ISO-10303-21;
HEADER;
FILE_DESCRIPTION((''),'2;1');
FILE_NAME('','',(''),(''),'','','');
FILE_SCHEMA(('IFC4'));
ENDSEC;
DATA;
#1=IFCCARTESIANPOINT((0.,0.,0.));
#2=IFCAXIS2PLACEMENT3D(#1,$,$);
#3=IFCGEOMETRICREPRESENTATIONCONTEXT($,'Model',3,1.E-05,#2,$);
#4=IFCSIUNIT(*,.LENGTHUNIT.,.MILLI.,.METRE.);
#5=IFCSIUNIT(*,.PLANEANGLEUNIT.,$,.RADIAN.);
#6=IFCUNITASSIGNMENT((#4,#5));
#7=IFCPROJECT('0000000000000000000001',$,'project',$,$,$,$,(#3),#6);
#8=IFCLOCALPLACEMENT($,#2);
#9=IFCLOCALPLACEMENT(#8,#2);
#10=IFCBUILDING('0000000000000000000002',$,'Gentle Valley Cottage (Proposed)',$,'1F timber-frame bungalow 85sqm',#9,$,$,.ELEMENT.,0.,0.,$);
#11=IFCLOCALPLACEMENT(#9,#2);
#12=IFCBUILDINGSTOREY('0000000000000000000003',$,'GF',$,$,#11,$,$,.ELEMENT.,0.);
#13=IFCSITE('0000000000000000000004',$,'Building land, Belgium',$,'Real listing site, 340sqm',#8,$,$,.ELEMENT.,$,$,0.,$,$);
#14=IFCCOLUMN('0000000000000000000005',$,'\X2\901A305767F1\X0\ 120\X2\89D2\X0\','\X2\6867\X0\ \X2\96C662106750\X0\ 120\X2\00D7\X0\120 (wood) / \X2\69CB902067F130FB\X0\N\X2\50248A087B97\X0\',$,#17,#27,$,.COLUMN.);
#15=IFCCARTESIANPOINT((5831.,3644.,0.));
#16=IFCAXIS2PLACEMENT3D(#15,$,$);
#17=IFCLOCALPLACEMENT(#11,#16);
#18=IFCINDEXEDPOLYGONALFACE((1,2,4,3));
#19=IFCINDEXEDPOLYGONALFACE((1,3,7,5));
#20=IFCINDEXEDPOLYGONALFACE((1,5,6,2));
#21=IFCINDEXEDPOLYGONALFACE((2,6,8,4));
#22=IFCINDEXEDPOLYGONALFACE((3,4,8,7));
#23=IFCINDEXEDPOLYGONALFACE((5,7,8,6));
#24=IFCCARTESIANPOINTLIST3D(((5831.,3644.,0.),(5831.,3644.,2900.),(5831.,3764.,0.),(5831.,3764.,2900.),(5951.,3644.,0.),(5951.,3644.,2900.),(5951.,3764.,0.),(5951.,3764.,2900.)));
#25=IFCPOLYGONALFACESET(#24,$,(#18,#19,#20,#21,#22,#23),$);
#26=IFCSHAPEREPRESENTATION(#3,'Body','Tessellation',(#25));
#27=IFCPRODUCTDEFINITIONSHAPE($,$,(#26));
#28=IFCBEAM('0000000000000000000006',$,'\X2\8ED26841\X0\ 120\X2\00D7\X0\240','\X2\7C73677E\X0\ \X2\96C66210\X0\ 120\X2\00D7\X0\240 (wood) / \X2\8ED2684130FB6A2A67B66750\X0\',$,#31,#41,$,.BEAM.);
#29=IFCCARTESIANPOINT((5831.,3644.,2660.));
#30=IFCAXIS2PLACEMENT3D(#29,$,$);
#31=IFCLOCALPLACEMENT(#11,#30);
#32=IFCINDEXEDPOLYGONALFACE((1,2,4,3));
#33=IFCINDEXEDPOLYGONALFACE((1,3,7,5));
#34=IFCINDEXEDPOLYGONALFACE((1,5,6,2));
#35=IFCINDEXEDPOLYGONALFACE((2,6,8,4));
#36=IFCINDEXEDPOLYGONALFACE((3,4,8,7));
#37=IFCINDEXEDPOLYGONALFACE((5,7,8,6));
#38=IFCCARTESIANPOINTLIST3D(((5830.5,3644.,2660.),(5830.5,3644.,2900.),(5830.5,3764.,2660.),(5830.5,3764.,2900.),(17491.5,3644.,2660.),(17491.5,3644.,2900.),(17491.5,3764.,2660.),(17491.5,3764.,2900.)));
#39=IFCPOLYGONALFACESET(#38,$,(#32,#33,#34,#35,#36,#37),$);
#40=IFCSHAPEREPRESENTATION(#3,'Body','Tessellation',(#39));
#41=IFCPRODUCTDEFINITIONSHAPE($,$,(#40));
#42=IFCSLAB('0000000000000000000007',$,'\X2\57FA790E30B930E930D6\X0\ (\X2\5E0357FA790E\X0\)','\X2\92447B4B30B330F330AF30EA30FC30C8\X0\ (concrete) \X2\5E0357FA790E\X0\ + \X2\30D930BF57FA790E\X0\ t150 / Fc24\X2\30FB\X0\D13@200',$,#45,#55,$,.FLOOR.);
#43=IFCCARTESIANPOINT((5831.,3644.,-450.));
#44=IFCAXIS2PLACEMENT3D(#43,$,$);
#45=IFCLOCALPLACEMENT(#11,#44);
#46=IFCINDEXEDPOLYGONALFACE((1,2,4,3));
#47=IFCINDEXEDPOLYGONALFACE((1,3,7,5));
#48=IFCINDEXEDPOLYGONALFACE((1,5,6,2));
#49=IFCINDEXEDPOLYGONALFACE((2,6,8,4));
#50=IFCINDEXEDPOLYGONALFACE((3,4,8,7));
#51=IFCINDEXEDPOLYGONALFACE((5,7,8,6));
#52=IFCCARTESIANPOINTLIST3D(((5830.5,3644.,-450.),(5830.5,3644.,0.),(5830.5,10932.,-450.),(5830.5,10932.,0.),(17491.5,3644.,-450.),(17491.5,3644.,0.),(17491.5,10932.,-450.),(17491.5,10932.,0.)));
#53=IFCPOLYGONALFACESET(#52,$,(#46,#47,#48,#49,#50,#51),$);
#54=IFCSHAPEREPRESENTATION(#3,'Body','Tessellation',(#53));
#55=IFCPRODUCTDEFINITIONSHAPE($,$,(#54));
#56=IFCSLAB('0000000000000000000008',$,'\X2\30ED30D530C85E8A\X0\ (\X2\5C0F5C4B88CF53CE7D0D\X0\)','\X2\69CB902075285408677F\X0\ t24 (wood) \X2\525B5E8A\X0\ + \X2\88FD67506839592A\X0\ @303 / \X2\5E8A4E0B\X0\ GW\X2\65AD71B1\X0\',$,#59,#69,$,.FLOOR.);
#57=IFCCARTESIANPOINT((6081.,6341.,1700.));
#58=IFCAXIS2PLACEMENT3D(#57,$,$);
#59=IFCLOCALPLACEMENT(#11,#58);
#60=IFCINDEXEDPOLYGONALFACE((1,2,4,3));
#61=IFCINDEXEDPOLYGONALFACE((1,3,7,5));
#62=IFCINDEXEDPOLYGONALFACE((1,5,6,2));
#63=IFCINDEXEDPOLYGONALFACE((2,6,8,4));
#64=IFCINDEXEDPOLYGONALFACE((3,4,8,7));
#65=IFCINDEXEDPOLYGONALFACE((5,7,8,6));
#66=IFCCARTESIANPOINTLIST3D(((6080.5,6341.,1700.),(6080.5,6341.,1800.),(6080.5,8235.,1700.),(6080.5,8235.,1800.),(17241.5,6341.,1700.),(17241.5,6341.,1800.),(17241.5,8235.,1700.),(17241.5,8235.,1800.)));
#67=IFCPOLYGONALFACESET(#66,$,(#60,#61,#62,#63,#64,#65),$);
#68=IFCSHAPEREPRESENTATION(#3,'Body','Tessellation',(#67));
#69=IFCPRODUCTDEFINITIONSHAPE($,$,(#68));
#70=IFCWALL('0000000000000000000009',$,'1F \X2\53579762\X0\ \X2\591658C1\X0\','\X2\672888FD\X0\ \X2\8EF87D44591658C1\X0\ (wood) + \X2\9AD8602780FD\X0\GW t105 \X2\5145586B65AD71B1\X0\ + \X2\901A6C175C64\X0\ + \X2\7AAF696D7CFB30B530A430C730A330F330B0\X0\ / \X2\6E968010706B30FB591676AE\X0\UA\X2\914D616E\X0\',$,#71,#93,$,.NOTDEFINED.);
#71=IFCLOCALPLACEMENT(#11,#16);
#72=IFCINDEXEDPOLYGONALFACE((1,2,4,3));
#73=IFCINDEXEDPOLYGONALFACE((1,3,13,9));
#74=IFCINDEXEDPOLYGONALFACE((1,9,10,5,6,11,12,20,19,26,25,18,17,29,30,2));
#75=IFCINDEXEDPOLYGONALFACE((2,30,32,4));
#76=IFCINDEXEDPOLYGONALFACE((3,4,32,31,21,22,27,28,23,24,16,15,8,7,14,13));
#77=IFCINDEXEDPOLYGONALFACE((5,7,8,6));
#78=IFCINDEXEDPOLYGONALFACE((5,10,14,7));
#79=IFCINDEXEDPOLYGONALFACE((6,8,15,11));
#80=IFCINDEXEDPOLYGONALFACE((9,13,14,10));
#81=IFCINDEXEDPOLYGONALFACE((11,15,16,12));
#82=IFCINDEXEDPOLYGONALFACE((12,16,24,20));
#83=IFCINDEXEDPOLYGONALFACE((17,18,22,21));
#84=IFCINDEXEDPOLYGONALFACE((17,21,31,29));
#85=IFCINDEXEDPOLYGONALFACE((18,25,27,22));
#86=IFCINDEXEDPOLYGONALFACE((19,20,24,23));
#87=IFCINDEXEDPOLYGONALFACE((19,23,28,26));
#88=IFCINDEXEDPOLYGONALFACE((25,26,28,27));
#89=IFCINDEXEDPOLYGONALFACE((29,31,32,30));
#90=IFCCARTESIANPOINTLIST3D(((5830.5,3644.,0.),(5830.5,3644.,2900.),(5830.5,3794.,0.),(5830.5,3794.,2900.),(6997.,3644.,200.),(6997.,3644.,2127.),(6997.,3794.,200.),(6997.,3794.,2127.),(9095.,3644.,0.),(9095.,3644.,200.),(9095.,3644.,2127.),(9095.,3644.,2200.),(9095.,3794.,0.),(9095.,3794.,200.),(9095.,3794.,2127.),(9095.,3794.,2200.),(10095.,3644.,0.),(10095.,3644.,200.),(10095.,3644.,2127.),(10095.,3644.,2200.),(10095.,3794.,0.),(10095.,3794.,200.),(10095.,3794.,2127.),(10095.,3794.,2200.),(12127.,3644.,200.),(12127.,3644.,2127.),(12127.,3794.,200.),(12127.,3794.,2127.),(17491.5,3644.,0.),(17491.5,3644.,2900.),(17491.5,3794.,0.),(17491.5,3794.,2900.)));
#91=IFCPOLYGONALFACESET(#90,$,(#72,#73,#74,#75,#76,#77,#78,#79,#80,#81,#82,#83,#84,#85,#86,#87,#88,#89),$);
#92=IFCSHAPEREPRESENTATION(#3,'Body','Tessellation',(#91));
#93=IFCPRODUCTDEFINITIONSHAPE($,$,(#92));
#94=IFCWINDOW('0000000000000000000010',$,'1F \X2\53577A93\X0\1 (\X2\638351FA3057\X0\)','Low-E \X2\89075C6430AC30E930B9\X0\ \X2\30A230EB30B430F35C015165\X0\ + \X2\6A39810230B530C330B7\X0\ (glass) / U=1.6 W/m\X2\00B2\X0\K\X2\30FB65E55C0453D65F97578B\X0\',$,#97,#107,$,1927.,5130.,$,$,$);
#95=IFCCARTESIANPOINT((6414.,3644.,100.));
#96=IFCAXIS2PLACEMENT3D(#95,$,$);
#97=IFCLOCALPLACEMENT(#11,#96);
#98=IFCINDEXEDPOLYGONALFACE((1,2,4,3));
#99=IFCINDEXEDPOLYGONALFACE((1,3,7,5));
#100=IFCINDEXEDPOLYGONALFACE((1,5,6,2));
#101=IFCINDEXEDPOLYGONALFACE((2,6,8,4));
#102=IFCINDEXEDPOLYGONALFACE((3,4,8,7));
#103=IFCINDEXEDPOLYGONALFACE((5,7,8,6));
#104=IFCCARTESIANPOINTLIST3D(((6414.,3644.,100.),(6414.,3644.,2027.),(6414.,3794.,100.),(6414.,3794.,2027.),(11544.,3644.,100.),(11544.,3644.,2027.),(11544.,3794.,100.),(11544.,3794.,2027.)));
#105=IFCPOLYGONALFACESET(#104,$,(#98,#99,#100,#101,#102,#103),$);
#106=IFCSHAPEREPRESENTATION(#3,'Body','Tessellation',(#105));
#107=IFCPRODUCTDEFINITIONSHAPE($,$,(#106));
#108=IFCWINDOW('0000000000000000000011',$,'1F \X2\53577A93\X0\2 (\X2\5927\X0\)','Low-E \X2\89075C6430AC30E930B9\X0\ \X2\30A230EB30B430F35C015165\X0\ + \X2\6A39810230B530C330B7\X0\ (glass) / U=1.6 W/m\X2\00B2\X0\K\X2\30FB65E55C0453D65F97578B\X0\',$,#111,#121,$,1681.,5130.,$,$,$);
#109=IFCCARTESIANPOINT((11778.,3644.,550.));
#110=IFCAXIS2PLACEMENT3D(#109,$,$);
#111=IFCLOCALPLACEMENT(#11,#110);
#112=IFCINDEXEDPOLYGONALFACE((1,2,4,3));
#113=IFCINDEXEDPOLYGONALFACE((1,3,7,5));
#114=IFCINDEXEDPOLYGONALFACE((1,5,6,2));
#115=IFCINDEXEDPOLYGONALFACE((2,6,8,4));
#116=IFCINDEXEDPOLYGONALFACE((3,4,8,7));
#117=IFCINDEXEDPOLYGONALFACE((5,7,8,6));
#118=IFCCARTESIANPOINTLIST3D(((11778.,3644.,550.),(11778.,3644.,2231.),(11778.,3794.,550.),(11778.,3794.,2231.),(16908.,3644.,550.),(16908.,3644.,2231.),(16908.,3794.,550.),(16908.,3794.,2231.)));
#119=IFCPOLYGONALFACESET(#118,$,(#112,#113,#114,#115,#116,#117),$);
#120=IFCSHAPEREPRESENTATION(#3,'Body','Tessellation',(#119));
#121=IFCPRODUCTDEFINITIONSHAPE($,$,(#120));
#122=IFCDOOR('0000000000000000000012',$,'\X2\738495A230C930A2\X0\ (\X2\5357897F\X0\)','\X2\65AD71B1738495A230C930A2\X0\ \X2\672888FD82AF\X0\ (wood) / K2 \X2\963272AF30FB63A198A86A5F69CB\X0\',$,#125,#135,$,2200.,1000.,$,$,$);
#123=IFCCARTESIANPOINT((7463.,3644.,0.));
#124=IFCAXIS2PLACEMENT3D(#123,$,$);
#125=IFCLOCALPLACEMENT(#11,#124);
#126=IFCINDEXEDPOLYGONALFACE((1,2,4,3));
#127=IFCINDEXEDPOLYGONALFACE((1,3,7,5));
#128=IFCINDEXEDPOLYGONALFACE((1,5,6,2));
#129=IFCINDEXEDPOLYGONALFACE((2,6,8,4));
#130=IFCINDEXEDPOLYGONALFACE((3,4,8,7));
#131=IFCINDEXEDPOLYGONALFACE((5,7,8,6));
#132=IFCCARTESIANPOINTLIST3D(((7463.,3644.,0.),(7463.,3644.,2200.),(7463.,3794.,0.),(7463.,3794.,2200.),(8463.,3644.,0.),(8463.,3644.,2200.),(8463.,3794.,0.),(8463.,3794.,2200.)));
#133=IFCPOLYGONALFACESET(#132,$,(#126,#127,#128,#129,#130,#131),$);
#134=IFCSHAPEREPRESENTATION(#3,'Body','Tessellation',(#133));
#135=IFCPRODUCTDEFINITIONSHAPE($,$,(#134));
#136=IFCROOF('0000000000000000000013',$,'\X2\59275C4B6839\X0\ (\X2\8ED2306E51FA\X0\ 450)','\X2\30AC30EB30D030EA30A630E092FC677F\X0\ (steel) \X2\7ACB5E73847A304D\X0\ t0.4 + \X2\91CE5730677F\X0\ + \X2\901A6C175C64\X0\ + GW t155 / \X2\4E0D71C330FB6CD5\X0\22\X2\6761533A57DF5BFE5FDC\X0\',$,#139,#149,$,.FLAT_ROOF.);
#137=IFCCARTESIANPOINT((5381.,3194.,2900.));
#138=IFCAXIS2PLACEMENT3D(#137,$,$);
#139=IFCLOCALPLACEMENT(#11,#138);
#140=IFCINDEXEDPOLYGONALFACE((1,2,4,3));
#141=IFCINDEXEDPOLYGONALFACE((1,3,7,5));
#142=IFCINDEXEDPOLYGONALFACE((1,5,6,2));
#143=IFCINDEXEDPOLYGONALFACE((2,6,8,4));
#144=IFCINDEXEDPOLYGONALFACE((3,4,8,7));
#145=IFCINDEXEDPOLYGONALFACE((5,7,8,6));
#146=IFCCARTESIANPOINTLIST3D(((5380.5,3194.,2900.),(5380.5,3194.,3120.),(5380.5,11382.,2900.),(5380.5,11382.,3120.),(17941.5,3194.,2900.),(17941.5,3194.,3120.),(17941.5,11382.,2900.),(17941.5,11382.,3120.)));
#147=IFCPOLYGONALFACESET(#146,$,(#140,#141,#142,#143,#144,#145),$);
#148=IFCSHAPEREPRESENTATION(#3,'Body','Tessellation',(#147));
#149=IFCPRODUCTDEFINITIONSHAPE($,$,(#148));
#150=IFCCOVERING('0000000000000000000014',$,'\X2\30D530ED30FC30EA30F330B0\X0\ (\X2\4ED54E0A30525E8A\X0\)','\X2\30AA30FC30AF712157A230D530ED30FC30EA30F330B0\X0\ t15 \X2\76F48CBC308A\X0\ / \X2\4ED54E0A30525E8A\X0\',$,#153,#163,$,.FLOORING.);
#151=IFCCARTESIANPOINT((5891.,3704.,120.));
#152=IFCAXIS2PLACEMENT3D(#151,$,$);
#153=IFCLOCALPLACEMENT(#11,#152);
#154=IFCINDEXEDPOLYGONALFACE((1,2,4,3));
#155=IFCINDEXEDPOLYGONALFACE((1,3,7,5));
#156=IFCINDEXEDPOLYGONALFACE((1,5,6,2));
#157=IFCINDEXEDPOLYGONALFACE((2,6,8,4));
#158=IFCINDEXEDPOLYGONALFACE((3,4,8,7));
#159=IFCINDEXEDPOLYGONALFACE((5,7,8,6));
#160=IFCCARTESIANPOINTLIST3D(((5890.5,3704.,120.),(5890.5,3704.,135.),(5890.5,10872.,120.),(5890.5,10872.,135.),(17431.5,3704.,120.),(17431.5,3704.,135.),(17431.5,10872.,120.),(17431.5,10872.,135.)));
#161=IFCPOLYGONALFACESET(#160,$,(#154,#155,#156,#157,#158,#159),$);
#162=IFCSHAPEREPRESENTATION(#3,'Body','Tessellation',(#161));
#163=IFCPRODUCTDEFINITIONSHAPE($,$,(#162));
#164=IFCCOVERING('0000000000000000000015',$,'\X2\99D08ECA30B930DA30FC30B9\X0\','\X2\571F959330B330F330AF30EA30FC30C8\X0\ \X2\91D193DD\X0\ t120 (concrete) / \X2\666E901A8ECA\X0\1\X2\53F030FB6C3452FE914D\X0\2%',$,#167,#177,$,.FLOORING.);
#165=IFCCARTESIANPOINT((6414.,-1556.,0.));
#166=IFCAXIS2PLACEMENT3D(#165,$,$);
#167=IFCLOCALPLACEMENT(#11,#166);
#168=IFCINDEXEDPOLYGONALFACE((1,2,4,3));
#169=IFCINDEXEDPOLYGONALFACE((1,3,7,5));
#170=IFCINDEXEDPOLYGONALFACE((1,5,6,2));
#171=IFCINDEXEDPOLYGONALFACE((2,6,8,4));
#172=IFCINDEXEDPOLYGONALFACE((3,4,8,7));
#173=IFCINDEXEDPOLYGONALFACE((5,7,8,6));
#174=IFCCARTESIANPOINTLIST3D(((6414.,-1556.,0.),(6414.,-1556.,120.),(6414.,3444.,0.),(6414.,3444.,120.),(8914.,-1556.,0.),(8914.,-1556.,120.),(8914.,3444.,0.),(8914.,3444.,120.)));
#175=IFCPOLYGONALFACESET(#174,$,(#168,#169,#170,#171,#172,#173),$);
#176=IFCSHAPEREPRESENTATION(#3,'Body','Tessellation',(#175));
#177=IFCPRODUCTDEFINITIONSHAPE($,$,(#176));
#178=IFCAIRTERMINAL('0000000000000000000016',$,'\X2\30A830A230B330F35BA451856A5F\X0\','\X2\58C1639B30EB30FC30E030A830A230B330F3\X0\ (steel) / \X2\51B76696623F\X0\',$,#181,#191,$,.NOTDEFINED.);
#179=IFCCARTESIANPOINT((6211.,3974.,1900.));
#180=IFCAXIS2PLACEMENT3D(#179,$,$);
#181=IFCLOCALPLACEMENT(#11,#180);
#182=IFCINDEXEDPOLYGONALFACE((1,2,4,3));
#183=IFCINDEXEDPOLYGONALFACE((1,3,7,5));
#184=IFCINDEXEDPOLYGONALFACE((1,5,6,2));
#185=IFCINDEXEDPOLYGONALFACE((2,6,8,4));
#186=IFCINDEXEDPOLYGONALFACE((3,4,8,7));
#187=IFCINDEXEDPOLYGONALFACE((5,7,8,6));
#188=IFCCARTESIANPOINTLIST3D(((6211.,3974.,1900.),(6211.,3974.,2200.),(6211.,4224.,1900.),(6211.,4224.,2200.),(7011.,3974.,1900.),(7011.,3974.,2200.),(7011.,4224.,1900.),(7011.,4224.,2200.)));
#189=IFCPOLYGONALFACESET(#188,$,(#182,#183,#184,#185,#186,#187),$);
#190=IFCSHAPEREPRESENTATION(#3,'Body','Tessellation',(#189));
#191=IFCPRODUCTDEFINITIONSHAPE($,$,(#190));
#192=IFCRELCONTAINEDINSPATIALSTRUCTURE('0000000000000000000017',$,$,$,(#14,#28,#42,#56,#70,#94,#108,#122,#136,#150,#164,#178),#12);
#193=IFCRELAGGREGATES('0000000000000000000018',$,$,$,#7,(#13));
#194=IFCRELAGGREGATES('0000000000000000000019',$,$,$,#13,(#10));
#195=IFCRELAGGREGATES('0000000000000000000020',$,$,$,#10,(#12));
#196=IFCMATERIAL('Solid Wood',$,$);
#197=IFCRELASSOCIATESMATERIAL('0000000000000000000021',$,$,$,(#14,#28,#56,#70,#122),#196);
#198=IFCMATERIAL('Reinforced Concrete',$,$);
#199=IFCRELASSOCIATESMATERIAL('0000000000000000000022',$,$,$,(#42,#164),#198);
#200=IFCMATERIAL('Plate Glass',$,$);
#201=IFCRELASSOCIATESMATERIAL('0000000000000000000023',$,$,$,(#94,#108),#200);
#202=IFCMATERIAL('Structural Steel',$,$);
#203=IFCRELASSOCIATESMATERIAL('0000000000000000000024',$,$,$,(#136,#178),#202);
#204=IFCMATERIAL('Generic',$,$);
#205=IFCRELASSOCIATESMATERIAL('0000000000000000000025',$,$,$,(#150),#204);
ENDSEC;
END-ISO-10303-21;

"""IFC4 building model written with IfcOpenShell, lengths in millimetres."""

from ifc_helpers import new_model, si_unit, frame, frame_2d, origin, place, context, project, spatial, rectangle, extrude, material, element, fill, save


model = new_model("IFC4")

# Units and contexts
model_context = context("Model", 3, precision=1e-05, world=origin())
ifc_project = project(units=[si_unit("LENGTHUNIT", "METRE", prefix="MILLI"), si_unit("PLANEANGLEUNIT", "RADIAN")], contexts=[model_context])

# Site, building, storey
site_placement = place(None, origin())
site = spatial("IfcSite", under=ifc_project, at=site_placement, Name="Building land, Belgium", ObjectType="Real listing site, 340sqm", CompositionType="ELEMENT", RefElevation=0.0)
building_placement = place(site_placement, origin())
building = spatial("IfcBuilding", under=site, at=building_placement, Name="Gentle Valley Cottage (Proposed)", ObjectType="1F timber-frame bungalow 85sqm", CompositionType="ELEMENT", ElevationOfRefHeight=0.0, ElevationOfTerrain=0.0)
storey_placement = place(building_placement, origin())
storey = spatial("IfcBuildingStorey", under=building, at=storey_placement, Name="GF", CompositionType="ELEMENT", Elevation=0.0)

# Column
ifc_material_1 = material(Name="Solid Wood")
column_1_placement = place(storey_placement, frame((5831.0, 3644.0, 0.0)))
element("IfcColumn", 1, at=column_1_placement, inside=storey, material=ifc_material_1, Name="通し柱 120角", Description="桧 集成材 120×120 (wood) / 構造柱・N値計算", PredefinedType="COLUMN", context=model_context, shape_type="SweptSolid", body=[
    extrude(rectangle(XDim=120.0, YDim=120.0, at=frame_2d((60.0, 60.0))), frame((5831.0, 3644.0, 0.0)), (0.0, 0.0, 1.0), 2900.0),
])

# Beam
beam_1_placement = place(storey_placement, frame((5831.0, 3644.0, 2660.0)))
element("IfcBeam", 2, at=beam_1_placement, inside=storey, material=ifc_material_1, Name="軒桁 120×240", Description="米松 集成 120×240 (wood) / 軒桁・横架材", PredefinedType="BEAM", context=model_context, shape_type="SweptSolid", body=[
    extrude(rectangle(XDim=11661.0, YDim=120.0, at=frame_2d((5830.0, 60.0))), frame((5831.0, 3644.0, 2660.0)), (0.0, 0.0, 1.0), 240.0),
])

# Slabs
ifc_material_2 = material(Name="Reinforced Concrete")
slab_1_placement = place(storey_placement, frame((5831.0, 3644.0, -450.0)))
element("IfcSlab", 3, at=slab_1_placement, inside=storey, material=ifc_material_2, Name="基礎スラブ (布基礎)", Description="鉄筋コンクリート (concrete) 布基礎 + ベタ基礎 t150 / Fc24・D13@200", PredefinedType="FLOOR", context=model_context, shape_type="SweptSolid", body=[
    extrude(rectangle(XDim=11661.0, YDim=7288.0, at=frame_2d((5830.0, 3644.0))), frame((5831.0, 3644.0, -450.0)), (0.0, 0.0, 1.0), 450.0),
])
slab_2_placement = place(storey_placement, frame((6081.0, 6341.0, 1700.0)))
element("IfcSlab", 4, at=slab_2_placement, inside=storey, material=ifc_material_1, Name="ロフト床 (小屋裏収納)", Description="構造用合板 t24 (wood) 剛床 + 製材根太 @303 / 床下 GW断熱", PredefinedType="FLOOR", context=model_context, shape_type="SweptSolid", body=[
    extrude(rectangle(XDim=11161.0, YDim=1894.0, at=frame_2d((5580.0, 947.0))), frame((6081.0, 6341.0, 1700.0)), (0.0, 0.0, 1.0), 100.0),
])

# Wall, openings, windows, door
wall_1_placement = place(storey_placement, frame((5831.0, 3644.0, 0.0)))
wall_1 = element("IfcWall", 5, at=wall_1_placement, inside=storey, material=ifc_material_1, Name="1F 南面 外壁", Description="木製 軸組外壁 (wood) + 高性能GW t105 充填断熱 + 通気層 + 窯業系サイディング / 準耐火・外皮UA配慮", PredefinedType="NOTDEFINED", context=model_context, shape_type="SweptSolid", body=[
    extrude(rectangle(XDim=11661.0, YDim=150.0, at=frame_2d((5830.0, 75.0))), frame((5831.0, 3644.0, 0.0)), (0.0, 0.0, 1.0), 2900.0),
])
opening_1_placement = place(storey_placement, frame((6414.0, 3644.0, 100.0)))
opening_1 = element("IfcOpeningElement", 6, at=opening_1_placement, cuts=wall_1, PredefinedType="NOTDEFINED", context=model_context, shape_type="SweptSolid", body=[
    extrude(rectangle(XDim=5130.0, YDim=150.0, at=frame_2d((2565.0, 75.0))), frame((6414.0, 3644.0, 100.0)), (0.0, 0.0, 1.0), 1927.0),
])
opening_2_placement = place(storey_placement, frame((11778.0, 3644.0, 550.0)))
opening_2 = element("IfcOpeningElement", 7, at=opening_2_placement, cuts=wall_1, PredefinedType="NOTDEFINED", context=model_context, shape_type="SweptSolid", body=[
    extrude(rectangle(XDim=5130.0, YDim=150.0, at=frame_2d((2565.0, 75.0))), frame((11778.0, 3644.0, 550.0)), (0.0, 0.0, 1.0), 1681.0),
])
opening_3_placement = place(storey_placement, frame((7463.0, 3644.0, 0.0)))
opening_3 = element("IfcOpeningElement", 8, at=opening_3_placement, cuts=wall_1, PredefinedType="NOTDEFINED", context=model_context, shape_type="SweptSolid", body=[
    extrude(rectangle(XDim=1000.0, YDim=150.0, at=frame_2d((500.0, 75.0))), frame((7463.0, 3644.0, 0.0)), (0.0, 0.0, 1.0), 2200.0),
])
ifc_material_3 = material(Name="Plate Glass")
window_1_placement = place(storey_placement, frame((6414.0, 3644.0, 100.0)))
window_1 = element("IfcWindow", 9, at=window_1_placement, inside=storey, material=ifc_material_3, Name="1F 南窓1 (掃出し)", Description="Low-E 複層ガラス アルゴン封入 + 樹脂サッシ (glass) / U=1.6 W/m²K・日射取得型", OverallHeight=1927.0, OverallWidth=5130.0, context=model_context, shape_type="SweptSolid", body=[
    extrude(rectangle(XDim=5130.0, YDim=150.0, at=frame_2d((2565.0, 75.0))), frame((6414.0, 3644.0, 100.0)), (0.0, 0.0, 1.0), 1927.0),
])
fill(opening_1, window_1)
window_2_placement = place(storey_placement, frame((11778.0, 3644.0, 550.0)))
window_2 = element("IfcWindow", 10, at=window_2_placement, inside=storey, material=ifc_material_3, Name="1F 南窓2 (大)", Description="Low-E 複層ガラス アルゴン封入 + 樹脂サッシ (glass) / U=1.6 W/m²K・日射取得型", OverallHeight=1681.0, OverallWidth=5130.0, context=model_context, shape_type="SweptSolid", body=[
    extrude(rectangle(XDim=5130.0, YDim=150.0, at=frame_2d((2565.0, 75.0))), frame((11778.0, 3644.0, 550.0)), (0.0, 0.0, 1.0), 1681.0),
])
fill(opening_2, window_2)
door_placement = place(storey_placement, frame((7463.0, 3644.0, 0.0)))
door = element("IfcDoor", 11, at=door_placement, inside=storey, material=ifc_material_1, Name="玄関ドア (南西)", Description="断熱玄関ドア 木製芯 (wood) / K2 防犯・採風機構", OverallHeight=2200.0, OverallWidth=1000.0, context=model_context, shape_type="SweptSolid", body=[
    extrude(rectangle(XDim=1000.0, YDim=150.0, at=frame_2d((500.0, 75.0))), frame((7463.0, 3644.0, 0.0)), (0.0, 0.0, 1.0), 2200.0),
])
fill(opening_3, door)

# Roof
ifc_material_4 = material(Name="Structural Steel")
roof_placement = place(storey_placement, frame((5381.0, 3194.0, 2900.0)))
element("IfcRoof", 12, at=roof_placement, inside=storey, material=ifc_material_4, Name="大屋根 (軒の出 450)", Description="ガルバリウム鋼板 (steel) 立平葺き t0.4 + 野地板 + 通気層 + GW t155 / 不燃・法22条区域対応", PredefinedType="FLAT_ROOF", context=model_context, shape_type="SweptSolid", body=[
    extrude(rectangle(XDim=12561.0, YDim=8188.0, at=frame_2d((6280.0, 4094.0))), frame((5381.0, 3194.0, 2900.0)), (0.0, 0.0, 1.0), 220.0),
])

# Coverings
ifc_material_5 = material(Name="Generic")
covering_1_placement = place(storey_placement, frame((5891.0, 3704.0, 120.0)))
element("IfcCovering", 13, at=covering_1_placement, inside=storey, material=ifc_material_5, Name="フローリング (仕上げ床)", Description="オーク無垢フローリング t15 直貼り / 仕上げ床", PredefinedType="FLOORING", context=model_context, shape_type="SweptSolid", body=[
    extrude(rectangle(XDim=11541.0, YDim=7168.0, at=frame_2d((5770.0, 3584.0))), frame((5891.0, 3704.0, 120.0)), (0.0, 0.0, 1.0), 15.0),
])
covering_2_placement = place(storey_placement, frame((6414.0, -1556.0, 0.0)))
element("IfcCovering", 14, at=covering_2_placement, inside=storey, material=ifc_material_2, Name="駐車スペース", Description="土間コンクリート 金鏝 t120 (concrete) / 普通車1台・水勾配2%", PredefinedType="FLOORING", context=model_context, shape_type="SweptSolid", body=[
    extrude(rectangle(XDim=2500.0, YDim=5000.0, at=frame_2d((1250.0, 2500.0))), frame((6414.0, -1556.0, 0.0)), (0.0, 0.0, 1.0), 120.0),
])

# Air terminal
air_terminal_placement = place(storey_placement, frame((6211.0, 3974.0, 1900.0)))
element("IfcAirTerminal", 15, at=air_terminal_placement, inside=storey, material=ifc_material_4, Name="エアコン室内機", Description="壁掛ルームエアコン (steel) / 冷暖房", PredefinedType="NOTDEFINED", context=model_context, shape_type="SweptSolid", body=[
    extrude(rectangle(XDim=800.0, YDim=250.0, at=frame_2d((400.0, 125.0))), frame((6211.0, 3974.0, 1900.0)), (0.0, 0.0, 1.0), 300.0),
])

save(model, "model.ifc")
